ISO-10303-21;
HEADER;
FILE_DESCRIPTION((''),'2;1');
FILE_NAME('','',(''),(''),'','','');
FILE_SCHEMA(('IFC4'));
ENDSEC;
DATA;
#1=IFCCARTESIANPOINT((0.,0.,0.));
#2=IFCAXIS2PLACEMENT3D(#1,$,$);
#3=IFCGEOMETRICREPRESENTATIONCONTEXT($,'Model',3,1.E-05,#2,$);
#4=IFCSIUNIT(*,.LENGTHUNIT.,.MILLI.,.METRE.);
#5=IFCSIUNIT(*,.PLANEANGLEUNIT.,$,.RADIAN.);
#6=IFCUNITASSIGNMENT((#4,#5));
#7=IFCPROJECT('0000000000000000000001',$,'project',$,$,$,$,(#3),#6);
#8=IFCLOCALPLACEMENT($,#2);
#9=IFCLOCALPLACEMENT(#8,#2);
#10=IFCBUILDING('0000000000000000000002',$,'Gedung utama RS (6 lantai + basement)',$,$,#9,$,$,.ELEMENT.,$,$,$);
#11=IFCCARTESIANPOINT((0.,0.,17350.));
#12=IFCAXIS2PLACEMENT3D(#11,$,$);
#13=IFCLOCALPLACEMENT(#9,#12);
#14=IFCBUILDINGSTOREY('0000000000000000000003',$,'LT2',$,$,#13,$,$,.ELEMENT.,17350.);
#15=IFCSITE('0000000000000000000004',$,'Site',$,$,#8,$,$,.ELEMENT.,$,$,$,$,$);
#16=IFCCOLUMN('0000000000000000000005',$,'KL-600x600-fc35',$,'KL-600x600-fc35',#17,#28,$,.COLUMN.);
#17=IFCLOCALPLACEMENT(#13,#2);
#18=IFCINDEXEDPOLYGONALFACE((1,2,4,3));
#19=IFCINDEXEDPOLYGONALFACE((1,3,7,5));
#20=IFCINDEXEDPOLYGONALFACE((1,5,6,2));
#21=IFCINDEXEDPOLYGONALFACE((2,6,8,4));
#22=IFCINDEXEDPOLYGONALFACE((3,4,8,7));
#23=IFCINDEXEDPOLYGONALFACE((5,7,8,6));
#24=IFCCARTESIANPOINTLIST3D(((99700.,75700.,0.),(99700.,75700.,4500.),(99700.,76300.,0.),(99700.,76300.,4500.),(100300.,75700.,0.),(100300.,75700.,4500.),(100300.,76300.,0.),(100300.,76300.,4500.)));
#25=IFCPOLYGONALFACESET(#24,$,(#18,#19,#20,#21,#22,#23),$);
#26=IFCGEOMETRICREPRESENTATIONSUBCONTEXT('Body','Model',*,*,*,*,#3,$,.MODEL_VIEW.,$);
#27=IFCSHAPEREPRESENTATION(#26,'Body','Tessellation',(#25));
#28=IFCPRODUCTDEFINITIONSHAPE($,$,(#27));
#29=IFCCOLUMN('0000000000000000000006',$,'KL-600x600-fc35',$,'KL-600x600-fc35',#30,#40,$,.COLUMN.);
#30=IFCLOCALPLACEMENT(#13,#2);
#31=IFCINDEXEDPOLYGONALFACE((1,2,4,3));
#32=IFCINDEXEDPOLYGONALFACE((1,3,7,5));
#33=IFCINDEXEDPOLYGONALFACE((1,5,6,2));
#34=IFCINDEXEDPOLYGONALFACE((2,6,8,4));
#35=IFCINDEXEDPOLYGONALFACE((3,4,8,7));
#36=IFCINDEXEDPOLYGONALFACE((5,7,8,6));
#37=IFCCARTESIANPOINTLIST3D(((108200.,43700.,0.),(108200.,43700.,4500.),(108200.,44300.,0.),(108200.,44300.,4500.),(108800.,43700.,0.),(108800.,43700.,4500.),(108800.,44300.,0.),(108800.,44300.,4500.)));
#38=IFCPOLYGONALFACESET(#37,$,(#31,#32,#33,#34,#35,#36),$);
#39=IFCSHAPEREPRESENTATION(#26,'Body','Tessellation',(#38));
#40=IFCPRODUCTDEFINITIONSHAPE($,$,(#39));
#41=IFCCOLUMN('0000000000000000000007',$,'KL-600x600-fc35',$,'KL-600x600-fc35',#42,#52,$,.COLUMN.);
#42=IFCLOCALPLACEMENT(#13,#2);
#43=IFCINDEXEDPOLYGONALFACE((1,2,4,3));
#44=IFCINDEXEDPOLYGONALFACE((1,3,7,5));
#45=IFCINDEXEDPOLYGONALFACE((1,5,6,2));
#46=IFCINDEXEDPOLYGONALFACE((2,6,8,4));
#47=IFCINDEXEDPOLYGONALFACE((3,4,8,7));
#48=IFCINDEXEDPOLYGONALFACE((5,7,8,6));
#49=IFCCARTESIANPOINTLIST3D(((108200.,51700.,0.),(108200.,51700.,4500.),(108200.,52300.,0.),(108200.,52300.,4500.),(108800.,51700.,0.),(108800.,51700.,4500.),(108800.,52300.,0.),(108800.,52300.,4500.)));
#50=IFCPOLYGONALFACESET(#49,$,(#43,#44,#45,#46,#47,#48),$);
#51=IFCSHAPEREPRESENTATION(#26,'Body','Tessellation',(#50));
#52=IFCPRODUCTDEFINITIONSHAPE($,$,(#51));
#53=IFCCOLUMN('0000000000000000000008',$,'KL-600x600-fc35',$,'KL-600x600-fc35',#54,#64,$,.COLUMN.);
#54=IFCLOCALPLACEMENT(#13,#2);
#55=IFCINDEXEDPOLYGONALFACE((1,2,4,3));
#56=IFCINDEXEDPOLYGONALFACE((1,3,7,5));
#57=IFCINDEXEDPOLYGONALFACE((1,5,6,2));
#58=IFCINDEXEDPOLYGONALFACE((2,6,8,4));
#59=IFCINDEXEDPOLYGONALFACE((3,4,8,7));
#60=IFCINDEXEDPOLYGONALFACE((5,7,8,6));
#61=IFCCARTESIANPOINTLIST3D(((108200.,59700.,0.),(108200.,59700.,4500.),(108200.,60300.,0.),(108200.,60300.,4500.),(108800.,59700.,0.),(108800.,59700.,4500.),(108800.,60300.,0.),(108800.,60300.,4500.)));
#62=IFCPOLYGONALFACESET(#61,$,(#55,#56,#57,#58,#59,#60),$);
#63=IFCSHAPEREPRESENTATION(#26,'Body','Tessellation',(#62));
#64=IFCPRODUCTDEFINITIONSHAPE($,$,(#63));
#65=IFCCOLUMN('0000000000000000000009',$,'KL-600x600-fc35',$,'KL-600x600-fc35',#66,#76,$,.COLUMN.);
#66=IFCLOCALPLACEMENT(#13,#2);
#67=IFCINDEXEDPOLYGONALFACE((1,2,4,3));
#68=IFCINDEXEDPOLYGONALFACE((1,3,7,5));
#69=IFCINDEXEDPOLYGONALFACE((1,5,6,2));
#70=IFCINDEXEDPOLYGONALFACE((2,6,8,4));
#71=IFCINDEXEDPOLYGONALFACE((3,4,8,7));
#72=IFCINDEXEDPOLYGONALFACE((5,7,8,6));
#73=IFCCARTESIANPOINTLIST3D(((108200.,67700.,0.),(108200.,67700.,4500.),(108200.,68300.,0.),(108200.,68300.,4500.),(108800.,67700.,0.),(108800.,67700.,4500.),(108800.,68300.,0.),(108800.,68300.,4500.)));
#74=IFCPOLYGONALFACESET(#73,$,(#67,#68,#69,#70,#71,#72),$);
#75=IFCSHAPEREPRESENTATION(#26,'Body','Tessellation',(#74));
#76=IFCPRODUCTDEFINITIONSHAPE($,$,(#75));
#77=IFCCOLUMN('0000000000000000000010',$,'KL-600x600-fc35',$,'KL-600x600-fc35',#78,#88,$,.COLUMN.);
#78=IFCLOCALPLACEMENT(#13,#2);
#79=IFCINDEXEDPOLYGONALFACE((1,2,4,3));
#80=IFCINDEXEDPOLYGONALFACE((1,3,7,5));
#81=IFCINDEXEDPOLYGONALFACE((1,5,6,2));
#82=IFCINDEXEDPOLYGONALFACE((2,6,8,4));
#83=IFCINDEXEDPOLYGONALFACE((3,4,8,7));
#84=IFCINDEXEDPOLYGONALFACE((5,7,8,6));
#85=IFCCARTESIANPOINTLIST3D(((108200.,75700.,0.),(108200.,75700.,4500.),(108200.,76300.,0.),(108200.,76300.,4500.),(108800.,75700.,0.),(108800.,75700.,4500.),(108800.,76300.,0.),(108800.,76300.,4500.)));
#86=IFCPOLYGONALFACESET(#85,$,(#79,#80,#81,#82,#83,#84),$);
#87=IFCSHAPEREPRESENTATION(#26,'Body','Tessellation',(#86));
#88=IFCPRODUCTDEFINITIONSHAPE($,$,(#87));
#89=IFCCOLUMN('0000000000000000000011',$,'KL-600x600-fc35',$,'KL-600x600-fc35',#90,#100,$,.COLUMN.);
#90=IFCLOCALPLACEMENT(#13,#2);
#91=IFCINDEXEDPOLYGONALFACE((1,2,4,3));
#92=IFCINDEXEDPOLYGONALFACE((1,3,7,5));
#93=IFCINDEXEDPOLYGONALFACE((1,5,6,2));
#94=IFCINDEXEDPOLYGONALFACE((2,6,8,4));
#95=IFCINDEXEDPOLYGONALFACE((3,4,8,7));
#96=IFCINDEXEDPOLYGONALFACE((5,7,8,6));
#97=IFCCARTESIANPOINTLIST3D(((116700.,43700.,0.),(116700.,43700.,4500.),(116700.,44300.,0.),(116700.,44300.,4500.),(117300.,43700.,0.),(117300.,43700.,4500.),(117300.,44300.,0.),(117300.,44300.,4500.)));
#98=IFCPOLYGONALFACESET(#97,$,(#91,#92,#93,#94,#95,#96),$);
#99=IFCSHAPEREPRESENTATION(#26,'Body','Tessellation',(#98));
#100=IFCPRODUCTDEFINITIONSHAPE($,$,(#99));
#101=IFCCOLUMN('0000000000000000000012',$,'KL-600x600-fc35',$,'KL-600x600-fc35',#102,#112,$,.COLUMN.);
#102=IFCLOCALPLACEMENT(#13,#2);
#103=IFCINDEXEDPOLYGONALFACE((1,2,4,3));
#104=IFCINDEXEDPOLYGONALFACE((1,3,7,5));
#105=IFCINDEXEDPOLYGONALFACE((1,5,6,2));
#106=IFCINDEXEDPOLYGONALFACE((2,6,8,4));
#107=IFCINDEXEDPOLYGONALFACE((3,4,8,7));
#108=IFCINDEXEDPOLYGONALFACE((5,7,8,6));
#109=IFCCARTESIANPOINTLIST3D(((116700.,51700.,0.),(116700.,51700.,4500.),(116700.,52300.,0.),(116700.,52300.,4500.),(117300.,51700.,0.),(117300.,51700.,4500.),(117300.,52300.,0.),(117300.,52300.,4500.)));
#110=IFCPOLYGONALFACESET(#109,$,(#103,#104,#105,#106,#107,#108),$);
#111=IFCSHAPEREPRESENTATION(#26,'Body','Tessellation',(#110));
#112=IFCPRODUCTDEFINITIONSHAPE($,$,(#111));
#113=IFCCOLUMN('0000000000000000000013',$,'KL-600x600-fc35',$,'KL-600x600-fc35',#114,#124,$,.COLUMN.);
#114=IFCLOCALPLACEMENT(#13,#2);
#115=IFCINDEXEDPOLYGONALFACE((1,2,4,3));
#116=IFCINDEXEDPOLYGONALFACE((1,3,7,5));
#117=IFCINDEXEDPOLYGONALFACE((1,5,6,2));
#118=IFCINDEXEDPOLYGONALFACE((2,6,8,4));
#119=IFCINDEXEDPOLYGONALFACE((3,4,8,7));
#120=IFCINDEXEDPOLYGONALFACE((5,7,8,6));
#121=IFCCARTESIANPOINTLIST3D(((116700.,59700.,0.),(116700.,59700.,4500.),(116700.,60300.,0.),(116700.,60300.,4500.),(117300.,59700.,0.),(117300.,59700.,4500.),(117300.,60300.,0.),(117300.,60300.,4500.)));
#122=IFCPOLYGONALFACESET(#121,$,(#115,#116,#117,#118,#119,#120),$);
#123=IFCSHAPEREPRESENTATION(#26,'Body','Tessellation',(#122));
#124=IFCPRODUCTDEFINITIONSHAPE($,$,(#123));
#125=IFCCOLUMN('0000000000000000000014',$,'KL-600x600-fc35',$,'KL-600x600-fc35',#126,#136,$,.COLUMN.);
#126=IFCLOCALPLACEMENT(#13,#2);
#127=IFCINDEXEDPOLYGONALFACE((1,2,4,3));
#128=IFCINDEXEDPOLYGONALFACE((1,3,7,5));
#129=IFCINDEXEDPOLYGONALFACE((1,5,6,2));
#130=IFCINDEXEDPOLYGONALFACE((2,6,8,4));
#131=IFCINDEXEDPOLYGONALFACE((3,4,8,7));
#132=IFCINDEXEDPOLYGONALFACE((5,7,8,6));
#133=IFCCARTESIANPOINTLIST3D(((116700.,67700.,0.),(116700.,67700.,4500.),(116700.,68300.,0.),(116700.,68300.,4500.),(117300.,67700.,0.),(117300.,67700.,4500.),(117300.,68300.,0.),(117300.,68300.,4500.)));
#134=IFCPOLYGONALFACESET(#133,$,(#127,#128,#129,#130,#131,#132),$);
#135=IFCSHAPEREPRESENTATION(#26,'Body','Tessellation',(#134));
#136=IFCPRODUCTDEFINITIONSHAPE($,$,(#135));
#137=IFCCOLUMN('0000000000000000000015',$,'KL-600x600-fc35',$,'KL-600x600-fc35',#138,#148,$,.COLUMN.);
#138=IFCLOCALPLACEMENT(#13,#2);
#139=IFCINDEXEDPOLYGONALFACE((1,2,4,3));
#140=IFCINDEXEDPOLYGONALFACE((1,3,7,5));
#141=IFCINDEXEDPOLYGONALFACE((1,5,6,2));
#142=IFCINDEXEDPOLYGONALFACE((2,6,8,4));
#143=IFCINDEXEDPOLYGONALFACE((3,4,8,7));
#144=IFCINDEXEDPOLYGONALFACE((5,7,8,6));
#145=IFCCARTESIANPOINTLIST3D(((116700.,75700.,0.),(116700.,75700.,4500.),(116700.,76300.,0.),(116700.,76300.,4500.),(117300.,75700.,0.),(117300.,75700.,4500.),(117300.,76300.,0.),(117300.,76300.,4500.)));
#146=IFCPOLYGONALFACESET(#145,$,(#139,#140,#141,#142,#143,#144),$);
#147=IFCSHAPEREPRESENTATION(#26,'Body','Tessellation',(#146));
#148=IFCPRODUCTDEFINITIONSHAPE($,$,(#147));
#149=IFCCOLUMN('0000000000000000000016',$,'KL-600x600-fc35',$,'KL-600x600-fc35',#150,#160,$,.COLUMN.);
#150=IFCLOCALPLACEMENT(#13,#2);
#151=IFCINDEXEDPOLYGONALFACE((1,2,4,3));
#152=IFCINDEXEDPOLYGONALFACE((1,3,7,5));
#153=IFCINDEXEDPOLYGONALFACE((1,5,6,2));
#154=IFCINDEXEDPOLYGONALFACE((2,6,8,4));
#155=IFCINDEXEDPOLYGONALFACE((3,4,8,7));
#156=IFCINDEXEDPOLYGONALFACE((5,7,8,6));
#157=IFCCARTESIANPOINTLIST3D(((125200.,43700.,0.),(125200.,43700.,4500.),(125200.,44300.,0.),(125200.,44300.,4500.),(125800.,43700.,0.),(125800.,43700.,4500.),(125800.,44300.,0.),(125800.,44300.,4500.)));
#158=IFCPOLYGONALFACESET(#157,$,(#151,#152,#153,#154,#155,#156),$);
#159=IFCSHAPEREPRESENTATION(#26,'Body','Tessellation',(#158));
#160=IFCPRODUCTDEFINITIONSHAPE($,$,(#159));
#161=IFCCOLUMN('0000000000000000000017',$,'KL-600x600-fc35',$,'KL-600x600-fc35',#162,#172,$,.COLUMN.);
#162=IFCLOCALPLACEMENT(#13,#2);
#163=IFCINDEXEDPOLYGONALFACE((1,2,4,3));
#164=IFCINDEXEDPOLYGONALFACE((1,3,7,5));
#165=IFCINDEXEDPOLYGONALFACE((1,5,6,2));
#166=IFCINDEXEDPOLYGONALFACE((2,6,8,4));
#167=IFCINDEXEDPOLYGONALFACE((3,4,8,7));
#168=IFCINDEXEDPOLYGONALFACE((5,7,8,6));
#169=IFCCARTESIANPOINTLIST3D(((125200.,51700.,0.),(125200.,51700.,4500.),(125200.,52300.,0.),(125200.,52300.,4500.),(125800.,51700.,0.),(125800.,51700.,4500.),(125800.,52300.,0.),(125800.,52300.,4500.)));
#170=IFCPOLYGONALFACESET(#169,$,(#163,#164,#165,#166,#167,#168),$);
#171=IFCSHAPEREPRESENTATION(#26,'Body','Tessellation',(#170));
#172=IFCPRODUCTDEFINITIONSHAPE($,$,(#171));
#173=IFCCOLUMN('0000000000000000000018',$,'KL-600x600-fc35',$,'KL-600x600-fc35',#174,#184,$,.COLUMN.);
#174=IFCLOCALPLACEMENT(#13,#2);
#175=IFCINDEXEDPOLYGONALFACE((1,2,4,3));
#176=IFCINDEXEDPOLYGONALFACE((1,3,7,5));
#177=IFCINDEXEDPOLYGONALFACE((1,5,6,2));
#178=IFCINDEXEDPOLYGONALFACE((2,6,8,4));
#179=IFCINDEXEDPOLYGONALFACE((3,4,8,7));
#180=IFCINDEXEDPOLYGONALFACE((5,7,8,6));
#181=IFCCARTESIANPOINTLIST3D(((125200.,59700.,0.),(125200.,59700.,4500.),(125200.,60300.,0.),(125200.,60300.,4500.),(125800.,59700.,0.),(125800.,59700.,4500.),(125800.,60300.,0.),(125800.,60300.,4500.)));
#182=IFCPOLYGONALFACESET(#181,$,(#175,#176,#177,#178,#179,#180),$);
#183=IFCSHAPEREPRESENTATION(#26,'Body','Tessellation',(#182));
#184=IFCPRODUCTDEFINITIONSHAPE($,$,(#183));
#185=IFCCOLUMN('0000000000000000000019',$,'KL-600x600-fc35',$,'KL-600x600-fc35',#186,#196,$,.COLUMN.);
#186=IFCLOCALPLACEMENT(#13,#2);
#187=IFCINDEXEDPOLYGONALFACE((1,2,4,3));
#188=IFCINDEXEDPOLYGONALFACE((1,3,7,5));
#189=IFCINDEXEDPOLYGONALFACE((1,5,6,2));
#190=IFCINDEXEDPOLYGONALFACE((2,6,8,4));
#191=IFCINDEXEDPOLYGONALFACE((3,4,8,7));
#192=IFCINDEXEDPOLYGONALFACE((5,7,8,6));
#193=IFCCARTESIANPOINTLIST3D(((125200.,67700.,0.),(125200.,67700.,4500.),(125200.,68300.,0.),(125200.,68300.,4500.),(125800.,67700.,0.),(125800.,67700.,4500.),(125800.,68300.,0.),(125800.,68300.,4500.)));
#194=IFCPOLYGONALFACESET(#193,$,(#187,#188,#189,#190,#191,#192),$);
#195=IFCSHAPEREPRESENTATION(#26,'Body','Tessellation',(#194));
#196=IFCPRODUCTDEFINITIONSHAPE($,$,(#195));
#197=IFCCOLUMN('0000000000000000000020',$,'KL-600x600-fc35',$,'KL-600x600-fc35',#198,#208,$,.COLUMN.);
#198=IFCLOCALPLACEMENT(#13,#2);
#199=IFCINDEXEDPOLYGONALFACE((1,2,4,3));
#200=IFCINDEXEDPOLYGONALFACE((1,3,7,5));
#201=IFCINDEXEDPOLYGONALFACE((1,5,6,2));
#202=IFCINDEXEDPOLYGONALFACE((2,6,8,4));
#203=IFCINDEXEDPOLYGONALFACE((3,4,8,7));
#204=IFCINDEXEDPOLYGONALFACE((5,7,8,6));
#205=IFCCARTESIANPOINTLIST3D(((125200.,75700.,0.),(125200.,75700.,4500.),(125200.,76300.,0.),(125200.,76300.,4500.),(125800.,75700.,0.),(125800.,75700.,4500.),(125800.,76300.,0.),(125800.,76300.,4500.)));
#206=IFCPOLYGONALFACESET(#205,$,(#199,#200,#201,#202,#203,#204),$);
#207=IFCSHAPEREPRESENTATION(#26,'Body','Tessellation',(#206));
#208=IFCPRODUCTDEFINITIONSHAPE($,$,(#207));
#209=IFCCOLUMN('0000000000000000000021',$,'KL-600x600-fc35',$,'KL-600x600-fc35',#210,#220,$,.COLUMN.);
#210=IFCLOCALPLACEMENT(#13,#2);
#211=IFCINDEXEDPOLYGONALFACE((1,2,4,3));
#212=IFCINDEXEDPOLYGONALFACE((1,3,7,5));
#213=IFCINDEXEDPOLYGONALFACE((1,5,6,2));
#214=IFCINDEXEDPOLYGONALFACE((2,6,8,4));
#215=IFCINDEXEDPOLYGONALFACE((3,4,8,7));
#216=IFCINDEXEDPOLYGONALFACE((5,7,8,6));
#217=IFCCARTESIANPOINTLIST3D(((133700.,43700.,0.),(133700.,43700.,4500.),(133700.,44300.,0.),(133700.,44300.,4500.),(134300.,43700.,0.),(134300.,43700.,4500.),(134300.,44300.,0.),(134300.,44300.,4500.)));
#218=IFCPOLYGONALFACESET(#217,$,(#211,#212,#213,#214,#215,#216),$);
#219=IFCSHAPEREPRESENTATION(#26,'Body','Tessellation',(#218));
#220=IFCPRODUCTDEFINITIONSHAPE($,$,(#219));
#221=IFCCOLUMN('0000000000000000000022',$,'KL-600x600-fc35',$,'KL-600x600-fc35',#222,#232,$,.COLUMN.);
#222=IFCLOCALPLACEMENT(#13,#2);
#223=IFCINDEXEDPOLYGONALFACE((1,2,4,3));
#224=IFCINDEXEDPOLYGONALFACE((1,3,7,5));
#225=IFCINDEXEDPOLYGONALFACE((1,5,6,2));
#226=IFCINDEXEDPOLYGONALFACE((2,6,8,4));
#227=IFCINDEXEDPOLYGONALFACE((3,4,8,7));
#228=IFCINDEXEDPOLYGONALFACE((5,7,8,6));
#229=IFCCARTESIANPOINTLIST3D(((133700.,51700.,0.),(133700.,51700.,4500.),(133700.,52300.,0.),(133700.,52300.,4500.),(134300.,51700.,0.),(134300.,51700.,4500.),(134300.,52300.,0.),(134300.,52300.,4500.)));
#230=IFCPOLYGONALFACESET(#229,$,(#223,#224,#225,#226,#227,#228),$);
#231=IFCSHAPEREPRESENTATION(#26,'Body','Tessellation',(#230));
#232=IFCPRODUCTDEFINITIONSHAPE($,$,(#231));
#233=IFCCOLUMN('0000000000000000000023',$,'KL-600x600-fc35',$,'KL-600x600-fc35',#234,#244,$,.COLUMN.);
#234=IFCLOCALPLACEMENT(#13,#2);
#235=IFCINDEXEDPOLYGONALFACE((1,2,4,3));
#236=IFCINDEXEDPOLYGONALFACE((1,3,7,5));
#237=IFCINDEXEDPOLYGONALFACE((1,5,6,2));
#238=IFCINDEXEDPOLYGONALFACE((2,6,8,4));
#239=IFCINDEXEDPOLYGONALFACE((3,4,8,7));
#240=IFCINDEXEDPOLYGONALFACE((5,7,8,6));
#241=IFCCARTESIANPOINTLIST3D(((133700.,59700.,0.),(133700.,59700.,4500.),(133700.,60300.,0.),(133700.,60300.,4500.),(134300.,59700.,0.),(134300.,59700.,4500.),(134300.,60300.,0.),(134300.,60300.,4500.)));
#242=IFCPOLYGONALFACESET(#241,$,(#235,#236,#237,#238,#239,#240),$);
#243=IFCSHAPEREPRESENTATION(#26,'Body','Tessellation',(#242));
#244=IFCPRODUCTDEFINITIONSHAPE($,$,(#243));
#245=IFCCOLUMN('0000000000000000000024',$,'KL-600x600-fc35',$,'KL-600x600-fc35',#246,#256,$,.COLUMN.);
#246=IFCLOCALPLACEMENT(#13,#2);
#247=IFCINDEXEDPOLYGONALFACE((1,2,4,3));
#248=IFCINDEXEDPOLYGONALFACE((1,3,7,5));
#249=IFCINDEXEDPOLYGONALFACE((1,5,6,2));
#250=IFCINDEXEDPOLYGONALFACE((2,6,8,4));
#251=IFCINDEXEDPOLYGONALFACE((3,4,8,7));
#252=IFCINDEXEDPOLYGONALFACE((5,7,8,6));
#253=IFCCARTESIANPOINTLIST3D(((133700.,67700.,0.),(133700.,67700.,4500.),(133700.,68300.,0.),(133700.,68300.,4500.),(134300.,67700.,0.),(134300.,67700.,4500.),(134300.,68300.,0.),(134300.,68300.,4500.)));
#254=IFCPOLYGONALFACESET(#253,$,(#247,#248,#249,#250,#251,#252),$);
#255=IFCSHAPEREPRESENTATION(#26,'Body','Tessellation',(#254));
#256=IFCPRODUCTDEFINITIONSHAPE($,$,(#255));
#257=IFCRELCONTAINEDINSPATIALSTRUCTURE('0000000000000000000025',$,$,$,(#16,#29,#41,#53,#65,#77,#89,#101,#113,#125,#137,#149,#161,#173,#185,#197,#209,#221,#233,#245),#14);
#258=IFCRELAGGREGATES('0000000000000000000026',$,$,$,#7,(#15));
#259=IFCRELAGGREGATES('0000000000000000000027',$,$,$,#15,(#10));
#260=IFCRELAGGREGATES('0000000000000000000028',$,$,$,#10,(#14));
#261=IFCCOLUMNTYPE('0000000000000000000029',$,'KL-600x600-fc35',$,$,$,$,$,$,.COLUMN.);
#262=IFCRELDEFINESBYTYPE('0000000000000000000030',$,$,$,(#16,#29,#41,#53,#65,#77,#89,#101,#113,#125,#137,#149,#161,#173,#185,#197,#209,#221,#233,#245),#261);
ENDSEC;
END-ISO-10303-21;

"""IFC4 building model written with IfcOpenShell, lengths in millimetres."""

from ifc_helpers import new_model, si_unit, frame, origin, origin_2d, place, context, subcontext, project, spatial, rectangle, extrude, material_profile, profile_set, profile_usage, type_object, element, save


model = new_model("IFC4")

# Units and contexts
model_context = context("Model", 3, precision=1e-05, world=origin())
body_context = subcontext(model_context, "Body", "Model", "MODEL_VIEW")
ifc_project = project(units=[si_unit("LENGTHUNIT", "METRE", prefix="MILLI"), si_unit("PLANEANGLEUNIT", "RADIAN")], contexts=[model_context])

# Site, building, storey
site_placement = place(None, origin())
site = spatial("IfcSite", under=ifc_project, at=site_placement, Name="Site", CompositionType="ELEMENT")
building_placement = place(site_placement, origin())
building = spatial("IfcBuilding", under=site, at=building_placement, Name="Gedung utama RS (6 lantai + basement)", CompositionType="ELEMENT")
storey_placement = place(building_placement, frame((0.0, 0.0, 17350.0)))
storey = spatial("IfcBuildingStorey", under=building, at=storey_placement, Name="LT2", CompositionType="ELEMENT", Elevation=17350.0)

# Columns
ifc_material_profile_1 = material_profile(None, rectangle(XDim=600.0, YDim=600.0, at=origin_2d()), Name="KL-600x600-fc35")
ifc_profile_set_1 = profile_set([ifc_material_profile_1], Name="KL-600x600-fc35")
ifc_profile_usage_1 = profile_usage(ifc_profile_set_1, cardinal=5)
column_type = type_object("IfcColumnType", Name="KL-600x600-fc35", PredefinedType="COLUMN", material=ifc_profile_set_1)
for number, where, z_axis, x_axis, name in (
    (1, (100000.0, 76000.0, 0.0), (0.0, 0.0, 1.0), (1.0, 0.0, 0.0), "KL-600x600-fc35"),
    (2, (108500.0, 44000.0, 0.0), (0.0, 0.0, 1.0), (1.0, 0.0, 0.0), "KL-600x600-fc35"),
    (3, (108500.0, 52000.0, 0.0), (0.0, 0.0, 1.0), (1.0, 0.0, 0.0), "KL-600x600-fc35"),
    (4, (108500.0, 60000.0, 0.0), (0.0, 0.0, 1.0), (1.0, 0.0, 0.0), "KL-600x600-fc35"),
    (5, (108500.0, 68000.0, 0.0), (0.0, 0.0, 1.0), (1.0, 0.0, 0.0), "KL-600x600-fc35"),
    (6, (108500.0, 76000.0, 0.0), (0.0, 0.0, 1.0), (1.0, 0.0, 0.0), "KL-600x600-fc35"),
    (7, (117000.0, 44000.0, 0.0), (0.0, 0.0, 1.0), (1.0, 0.0, 0.0), "KL-600x600-fc35"),
    (8, (117000.0, 52000.0, 0.0), (0.0, 0.0, 1.0), (1.0, 0.0, 0.0), "KL-600x600-fc35"),
    (9, (117000.0, 60000.0, 0.0), (0.0, 0.0, 1.0), (1.0, 0.0, 0.0), "KL-600x600-fc35"),
    (10, (117000.0, 68000.0, 0.0), (0.0, 0.0, 1.0), (1.0, 0.0, 0.0), "KL-600x600-fc35"),
    (11, (117000.0, 76000.0, 0.0), (0.0, 0.0, 1.0), (1.0, 0.0, 0.0), "KL-600x600-fc35"),
    (12, (125500.0, 44000.0, 0.0), (0.0, 0.0, 1.0), (1.0, 0.0, 0.0), "KL-600x600-fc35"),
    (13, (125500.0, 52000.0, 0.0), (0.0, 0.0, 1.0), (1.0, 0.0, 0.0), "KL-600x600-fc35"),
    (14, (125500.0, 60000.0, 0.0), (0.0, 0.0, 1.0), (1.0, 0.0, 0.0), "KL-600x600-fc35"),
    (15, (125500.0, 68000.0, 0.0), (0.0, 0.0, 1.0), (1.0, 0.0, 0.0), "KL-600x600-fc35"),
    (16, (125500.0, 76000.0, 0.0), (0.0, 0.0, 1.0), (1.0, 0.0, 0.0), "KL-600x600-fc35"),
    (17, (134000.0, 44000.0, 0.0), (0.0, 0.0, 1.0), (1.0, 0.0, 0.0), "KL-600x600-fc35"),
    (18, (134000.0, 52000.0, 0.0), (0.0, 0.0, 1.0), (1.0, 0.0, 0.0), "KL-600x600-fc35"),
    (19, (134000.0, 60000.0, 0.0), (0.0, 0.0, 1.0), (1.0, 0.0, 0.0), "KL-600x600-fc35"),
    (20, (134000.0, 68000.0, 0.0), (0.0, 0.0, 1.0), (1.0, 0.0, 0.0), "KL-600x600-fc35"),
):
    element("IfcColumn", number, at=place(storey_placement, frame(where, z_axis=z_axis, x_axis=x_axis)), inside=storey, type_object=column_type, material=ifc_profile_usage_1, Name=name, ObjectType="KL-600x600-fc35", PredefinedType="COLUMN", context=body_context, shape_type="SweptSolid", body=[
        extrude(rectangle(XDim=600.0, YDim=600.0, at=origin_2d()), origin(), (0.0, 0.0, 1.0), 4500.0),
    ])

save(model, "model.ifc")
